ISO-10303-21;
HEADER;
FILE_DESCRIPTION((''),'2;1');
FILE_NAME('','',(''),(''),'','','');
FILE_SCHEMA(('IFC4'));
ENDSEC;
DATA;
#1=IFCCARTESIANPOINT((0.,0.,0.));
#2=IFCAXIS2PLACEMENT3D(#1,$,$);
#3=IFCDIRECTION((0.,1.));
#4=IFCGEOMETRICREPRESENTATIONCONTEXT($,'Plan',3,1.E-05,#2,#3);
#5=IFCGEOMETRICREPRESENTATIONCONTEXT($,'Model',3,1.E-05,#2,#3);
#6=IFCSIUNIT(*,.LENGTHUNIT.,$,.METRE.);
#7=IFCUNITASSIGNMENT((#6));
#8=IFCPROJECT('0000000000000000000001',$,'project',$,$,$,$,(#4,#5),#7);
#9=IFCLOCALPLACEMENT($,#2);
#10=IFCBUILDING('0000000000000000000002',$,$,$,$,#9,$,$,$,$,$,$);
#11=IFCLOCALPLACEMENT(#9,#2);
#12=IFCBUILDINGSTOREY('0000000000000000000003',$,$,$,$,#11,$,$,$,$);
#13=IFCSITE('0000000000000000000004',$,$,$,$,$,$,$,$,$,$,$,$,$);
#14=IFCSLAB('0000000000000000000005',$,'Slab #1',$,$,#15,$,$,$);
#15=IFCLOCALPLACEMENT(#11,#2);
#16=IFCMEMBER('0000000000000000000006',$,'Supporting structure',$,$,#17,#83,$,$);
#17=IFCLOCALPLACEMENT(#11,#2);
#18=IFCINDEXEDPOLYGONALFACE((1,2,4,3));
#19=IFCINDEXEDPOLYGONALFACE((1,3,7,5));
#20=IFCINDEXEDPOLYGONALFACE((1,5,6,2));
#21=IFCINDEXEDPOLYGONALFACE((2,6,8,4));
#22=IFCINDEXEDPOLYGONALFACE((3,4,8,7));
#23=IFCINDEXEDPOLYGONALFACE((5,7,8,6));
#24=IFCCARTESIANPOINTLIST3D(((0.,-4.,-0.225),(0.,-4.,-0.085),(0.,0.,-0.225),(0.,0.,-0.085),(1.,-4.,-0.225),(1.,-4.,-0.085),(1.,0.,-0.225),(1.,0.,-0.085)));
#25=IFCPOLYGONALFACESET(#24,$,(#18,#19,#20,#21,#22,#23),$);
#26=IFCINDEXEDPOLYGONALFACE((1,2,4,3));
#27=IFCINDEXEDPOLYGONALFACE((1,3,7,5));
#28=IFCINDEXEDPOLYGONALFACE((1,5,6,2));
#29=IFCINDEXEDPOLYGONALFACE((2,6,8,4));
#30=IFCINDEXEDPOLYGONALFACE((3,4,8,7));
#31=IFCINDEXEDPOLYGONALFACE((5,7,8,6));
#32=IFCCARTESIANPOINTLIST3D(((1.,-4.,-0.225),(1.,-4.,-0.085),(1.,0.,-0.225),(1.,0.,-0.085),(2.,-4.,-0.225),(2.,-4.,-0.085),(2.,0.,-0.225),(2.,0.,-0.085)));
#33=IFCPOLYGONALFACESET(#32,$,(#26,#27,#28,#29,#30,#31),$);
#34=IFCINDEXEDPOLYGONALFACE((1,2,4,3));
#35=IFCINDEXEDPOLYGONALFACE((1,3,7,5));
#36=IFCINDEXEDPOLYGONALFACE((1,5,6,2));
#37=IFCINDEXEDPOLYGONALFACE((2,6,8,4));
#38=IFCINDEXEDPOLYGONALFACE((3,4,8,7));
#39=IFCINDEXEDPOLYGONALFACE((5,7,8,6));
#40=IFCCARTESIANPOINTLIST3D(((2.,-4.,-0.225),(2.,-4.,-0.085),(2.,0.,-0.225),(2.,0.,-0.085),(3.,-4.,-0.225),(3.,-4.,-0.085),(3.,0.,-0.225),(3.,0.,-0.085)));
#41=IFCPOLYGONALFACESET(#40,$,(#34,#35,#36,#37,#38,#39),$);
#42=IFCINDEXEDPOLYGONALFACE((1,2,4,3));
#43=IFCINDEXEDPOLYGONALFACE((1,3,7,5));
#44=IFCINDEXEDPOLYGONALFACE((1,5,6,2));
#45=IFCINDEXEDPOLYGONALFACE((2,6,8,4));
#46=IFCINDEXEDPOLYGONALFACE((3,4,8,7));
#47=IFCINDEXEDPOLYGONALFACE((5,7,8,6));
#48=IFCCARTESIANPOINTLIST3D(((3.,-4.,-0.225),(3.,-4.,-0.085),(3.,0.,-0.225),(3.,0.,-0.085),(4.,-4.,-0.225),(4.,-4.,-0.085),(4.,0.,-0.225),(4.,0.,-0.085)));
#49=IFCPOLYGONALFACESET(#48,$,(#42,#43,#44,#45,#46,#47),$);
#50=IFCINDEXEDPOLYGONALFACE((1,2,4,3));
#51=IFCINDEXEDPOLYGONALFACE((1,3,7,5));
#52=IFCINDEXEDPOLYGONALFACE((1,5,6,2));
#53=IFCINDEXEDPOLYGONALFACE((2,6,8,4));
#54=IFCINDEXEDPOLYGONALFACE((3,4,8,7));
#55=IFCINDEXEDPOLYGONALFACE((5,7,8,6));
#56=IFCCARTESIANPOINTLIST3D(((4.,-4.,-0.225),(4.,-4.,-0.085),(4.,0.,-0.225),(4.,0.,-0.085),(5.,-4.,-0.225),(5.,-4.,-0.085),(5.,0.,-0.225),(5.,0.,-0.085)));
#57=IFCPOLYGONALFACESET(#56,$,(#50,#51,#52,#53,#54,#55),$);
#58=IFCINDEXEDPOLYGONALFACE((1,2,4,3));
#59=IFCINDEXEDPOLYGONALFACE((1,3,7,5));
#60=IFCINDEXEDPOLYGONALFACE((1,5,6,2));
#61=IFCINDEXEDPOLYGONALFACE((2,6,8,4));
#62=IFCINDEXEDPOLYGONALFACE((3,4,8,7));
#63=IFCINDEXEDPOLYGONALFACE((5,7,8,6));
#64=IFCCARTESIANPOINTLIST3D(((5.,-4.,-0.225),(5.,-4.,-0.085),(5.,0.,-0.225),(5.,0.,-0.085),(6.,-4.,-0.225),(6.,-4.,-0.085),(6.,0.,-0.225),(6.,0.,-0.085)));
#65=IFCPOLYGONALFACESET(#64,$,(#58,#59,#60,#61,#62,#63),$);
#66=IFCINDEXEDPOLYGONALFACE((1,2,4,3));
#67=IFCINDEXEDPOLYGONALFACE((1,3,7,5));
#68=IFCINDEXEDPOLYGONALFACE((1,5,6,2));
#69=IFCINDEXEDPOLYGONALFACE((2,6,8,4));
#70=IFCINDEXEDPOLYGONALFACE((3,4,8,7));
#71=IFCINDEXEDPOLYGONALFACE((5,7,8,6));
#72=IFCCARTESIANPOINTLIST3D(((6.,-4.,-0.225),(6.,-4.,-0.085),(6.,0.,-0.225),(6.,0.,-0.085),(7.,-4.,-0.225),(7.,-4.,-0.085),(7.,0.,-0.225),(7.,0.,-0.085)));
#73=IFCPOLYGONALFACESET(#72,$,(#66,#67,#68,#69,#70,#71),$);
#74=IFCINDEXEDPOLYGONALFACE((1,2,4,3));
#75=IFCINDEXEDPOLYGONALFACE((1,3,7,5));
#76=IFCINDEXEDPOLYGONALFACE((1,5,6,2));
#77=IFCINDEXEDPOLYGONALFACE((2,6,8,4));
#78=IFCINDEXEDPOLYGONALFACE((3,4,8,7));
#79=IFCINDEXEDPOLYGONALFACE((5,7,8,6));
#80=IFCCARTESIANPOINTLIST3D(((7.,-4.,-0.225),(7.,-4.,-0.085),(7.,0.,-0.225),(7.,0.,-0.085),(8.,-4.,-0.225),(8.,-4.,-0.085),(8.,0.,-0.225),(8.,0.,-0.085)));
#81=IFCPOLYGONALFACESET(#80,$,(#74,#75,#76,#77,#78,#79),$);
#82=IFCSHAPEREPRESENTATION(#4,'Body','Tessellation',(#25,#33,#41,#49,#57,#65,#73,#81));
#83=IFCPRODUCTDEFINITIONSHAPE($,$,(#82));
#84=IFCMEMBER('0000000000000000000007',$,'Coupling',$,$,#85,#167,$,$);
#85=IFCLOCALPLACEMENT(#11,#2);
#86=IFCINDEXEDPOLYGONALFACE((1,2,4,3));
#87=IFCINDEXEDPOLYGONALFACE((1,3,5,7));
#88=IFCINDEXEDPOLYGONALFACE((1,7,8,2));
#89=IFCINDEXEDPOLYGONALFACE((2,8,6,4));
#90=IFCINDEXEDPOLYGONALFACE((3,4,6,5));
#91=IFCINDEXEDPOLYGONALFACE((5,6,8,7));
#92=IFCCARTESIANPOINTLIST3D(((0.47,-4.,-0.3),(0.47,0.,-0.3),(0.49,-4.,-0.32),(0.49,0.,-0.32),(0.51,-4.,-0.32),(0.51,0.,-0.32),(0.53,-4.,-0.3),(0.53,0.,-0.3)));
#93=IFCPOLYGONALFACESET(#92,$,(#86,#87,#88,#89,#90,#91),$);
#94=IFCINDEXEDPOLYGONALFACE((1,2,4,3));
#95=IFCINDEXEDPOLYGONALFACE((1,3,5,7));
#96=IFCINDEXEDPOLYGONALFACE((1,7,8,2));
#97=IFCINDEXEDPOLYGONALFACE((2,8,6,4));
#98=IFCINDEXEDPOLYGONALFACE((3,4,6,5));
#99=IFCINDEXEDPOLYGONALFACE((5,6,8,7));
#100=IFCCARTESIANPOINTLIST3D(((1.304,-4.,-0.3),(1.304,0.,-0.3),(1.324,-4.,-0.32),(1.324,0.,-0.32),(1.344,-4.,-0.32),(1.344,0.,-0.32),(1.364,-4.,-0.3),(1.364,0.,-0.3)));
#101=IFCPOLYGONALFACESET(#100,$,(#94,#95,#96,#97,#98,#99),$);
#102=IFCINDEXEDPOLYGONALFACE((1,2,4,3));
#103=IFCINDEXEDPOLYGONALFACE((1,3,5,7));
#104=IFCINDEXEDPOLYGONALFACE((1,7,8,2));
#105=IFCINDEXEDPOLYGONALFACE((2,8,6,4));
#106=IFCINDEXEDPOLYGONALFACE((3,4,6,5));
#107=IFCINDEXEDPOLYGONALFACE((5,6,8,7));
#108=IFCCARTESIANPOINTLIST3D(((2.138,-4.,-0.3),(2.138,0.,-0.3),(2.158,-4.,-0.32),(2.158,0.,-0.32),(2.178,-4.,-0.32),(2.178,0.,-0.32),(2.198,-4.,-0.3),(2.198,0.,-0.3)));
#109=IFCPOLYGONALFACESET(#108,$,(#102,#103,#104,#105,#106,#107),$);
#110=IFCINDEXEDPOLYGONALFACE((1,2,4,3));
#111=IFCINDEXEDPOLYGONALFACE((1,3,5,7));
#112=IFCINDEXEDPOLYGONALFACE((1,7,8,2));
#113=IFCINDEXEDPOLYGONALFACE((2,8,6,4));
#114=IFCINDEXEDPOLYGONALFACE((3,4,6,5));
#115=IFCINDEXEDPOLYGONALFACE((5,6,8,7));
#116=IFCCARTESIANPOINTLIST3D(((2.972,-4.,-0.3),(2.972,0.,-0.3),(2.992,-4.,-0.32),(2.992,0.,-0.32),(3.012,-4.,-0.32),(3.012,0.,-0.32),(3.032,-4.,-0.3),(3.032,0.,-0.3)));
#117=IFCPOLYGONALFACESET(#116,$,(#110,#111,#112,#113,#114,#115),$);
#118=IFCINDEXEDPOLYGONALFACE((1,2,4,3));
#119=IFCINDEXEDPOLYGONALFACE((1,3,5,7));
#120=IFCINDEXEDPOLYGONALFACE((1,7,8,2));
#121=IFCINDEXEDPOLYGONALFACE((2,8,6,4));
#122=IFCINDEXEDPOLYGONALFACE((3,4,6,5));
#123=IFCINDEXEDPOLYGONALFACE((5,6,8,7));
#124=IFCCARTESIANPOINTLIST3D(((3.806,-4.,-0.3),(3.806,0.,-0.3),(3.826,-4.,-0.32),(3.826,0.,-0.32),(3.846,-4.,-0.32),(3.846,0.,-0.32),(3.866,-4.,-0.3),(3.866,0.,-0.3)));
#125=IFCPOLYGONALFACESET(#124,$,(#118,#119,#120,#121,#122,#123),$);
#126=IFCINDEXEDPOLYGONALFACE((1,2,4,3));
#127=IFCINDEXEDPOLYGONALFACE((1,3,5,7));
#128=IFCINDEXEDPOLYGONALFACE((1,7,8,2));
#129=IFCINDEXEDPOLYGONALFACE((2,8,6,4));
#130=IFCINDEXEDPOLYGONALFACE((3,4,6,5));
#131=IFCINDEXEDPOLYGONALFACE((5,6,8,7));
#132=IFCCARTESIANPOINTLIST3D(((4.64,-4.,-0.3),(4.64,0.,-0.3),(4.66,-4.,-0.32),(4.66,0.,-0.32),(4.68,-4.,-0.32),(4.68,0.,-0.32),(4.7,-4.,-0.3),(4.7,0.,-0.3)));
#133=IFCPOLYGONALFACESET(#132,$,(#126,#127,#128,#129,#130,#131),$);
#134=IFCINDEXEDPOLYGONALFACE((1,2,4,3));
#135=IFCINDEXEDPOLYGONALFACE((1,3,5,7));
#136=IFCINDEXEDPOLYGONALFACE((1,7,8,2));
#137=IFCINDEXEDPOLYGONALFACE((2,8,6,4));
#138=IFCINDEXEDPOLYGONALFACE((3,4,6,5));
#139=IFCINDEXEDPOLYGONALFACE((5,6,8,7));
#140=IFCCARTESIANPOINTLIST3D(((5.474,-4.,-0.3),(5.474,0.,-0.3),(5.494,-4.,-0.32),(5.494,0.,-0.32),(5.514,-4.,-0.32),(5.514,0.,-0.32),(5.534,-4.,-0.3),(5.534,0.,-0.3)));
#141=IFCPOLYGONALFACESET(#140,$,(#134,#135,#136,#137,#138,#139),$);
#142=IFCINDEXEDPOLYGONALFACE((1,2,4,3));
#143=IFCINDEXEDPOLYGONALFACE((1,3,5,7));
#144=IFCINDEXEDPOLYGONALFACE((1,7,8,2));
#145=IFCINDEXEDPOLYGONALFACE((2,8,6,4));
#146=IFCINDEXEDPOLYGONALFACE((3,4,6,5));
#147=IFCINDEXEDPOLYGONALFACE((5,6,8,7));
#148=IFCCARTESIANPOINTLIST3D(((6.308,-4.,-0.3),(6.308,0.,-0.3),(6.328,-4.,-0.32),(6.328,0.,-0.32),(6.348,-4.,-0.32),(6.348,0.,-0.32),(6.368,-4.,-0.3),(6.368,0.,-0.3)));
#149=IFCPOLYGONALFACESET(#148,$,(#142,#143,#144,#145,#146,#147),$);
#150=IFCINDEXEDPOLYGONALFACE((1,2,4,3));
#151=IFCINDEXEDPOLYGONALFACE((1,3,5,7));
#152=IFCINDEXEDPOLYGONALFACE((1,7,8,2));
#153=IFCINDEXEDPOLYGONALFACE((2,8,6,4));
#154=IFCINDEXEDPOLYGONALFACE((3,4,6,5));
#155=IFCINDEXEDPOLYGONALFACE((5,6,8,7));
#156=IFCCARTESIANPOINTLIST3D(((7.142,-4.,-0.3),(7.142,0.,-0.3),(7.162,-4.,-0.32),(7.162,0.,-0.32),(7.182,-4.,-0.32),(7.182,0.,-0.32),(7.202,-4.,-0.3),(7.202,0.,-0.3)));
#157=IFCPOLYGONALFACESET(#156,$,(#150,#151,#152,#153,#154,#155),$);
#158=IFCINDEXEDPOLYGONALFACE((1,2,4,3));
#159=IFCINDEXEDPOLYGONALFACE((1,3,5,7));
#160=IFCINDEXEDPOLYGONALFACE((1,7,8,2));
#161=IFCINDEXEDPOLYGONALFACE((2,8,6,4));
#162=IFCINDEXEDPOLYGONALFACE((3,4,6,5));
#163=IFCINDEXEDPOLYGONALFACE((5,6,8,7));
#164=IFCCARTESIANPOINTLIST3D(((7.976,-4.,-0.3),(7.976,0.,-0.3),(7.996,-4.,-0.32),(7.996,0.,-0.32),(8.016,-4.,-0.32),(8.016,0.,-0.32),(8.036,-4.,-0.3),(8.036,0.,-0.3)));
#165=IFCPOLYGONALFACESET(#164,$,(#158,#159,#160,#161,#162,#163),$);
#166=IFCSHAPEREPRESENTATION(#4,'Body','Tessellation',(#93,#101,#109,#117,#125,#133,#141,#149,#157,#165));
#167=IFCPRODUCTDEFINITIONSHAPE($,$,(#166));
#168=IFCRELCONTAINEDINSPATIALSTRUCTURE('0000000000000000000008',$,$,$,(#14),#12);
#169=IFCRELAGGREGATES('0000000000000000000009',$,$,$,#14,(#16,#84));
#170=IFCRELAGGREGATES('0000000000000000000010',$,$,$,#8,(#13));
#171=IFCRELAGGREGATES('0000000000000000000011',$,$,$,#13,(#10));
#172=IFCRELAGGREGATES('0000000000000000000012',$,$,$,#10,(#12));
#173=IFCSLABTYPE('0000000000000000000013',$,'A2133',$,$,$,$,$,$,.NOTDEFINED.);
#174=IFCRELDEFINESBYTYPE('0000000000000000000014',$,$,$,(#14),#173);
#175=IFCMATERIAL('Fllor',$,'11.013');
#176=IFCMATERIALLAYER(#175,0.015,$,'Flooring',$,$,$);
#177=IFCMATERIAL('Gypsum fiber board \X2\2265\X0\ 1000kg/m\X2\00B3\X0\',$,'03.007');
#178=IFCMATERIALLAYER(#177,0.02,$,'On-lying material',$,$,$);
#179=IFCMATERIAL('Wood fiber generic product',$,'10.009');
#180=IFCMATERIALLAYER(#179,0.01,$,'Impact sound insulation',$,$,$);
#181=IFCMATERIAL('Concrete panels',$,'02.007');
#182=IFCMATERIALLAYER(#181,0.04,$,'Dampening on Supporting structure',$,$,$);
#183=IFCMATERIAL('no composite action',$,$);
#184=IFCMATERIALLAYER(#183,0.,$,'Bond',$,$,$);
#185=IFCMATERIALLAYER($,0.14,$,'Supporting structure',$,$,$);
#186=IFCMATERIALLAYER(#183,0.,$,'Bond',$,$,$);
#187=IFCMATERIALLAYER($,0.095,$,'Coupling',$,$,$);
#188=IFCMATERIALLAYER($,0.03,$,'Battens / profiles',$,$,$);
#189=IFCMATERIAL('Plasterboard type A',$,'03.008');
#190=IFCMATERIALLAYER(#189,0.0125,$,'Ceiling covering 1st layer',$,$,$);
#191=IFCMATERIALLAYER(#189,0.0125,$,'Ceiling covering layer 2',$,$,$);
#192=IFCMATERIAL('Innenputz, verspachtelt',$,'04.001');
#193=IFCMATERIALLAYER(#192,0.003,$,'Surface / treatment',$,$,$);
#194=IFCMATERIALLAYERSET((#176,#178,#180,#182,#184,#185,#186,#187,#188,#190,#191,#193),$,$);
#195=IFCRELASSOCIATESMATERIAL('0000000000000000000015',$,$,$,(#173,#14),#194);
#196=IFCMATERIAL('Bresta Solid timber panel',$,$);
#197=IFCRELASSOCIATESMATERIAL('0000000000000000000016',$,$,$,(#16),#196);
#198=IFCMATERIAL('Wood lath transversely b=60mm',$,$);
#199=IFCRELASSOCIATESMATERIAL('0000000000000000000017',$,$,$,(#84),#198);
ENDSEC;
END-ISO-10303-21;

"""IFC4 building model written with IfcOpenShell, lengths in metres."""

from ifc_helpers import new_model, si_unit, direction, frame, frame_2d, origin, place, context, project, spatial, polyline, rectangle, outline, extrude, material, layer, layer_set, type_object, element, aggregate, save


model = new_model("IFC4")

# Units and contexts
plan_context = context("Plan", 3, precision=1e-05, world=origin(), true_north=direction((0.0, 1.0)))
model_context = context("Model", 3, precision=1e-05, world=origin(), true_north=direction((0.0, 1.0)))
ifc_project = project(units=[si_unit("LENGTHUNIT", "METRE")], contexts=[plan_context, model_context])

# Site, building, storey
site = spatial("IfcSite", under=ifc_project)
building_placement = place(None, origin())
building = spatial("IfcBuilding", under=site, at=building_placement)
storey_placement = place(building_placement, origin())
storey = spatial("IfcBuildingStorey", under=building, at=storey_placement)

# Slab, members
ifc_material_1 = material(Name="Fllor", Category="11.013")
ifc_layer_1 = layer(ifc_material_1, 0.015, Name="Flooring")
ifc_material_2 = material(Name="Gypsum fiber board ≥ 1000kg/m³", Category="03.007")
ifc_layer_2 = layer(ifc_material_2, 0.02, Name="On-lying material")
ifc_material_3 = material(Name="Wood fiber generic product", Category="10.009")
ifc_layer_3 = layer(ifc_material_3, 0.01, Name="Impact sound insulation")
ifc_material_4 = material(Name="Concrete panels", Category="02.007")
ifc_layer_4 = layer(ifc_material_4, 0.04, Name="Dampening on Supporting structure")
ifc_material_5 = material(Name="no composite action")
ifc_layer_5 = layer(ifc_material_5, 0.0, Name="Bond")
ifc_layer_6 = layer(None, 0.14, Name="Supporting structure")
ifc_layer_7 = layer(ifc_material_5, 0.0, Name="Bond")
ifc_layer_8 = layer(None, 0.095, Name="Coupling")
ifc_layer_9 = layer(None, 0.03, Name="Battens / profiles")
ifc_material_6 = material(Name="Plasterboard type A", Category="03.008")
ifc_layer_10 = layer(ifc_material_6, 0.0125, Name="Ceiling covering 1st layer")
ifc_layer_11 = layer(ifc_material_6, 0.0125, Name="Ceiling covering layer 2")
ifc_material_7 = material(Name="Innenputz, verspachtelt", Category="04.001")
ifc_layer_12 = layer(ifc_material_7, 0.003, Name="Surface / treatment")
ifc_layer_set = layer_set([ifc_layer_1, ifc_layer_2, ifc_layer_3, ifc_layer_4, ifc_layer_5, ifc_layer_6, ifc_layer_7, ifc_layer_8, ifc_layer_9, ifc_layer_10, ifc_layer_11, ifc_layer_12])
slab_type = type_object("IfcSlabType", Name="A2133", PredefinedType="NOTDEFINED", material=ifc_layer_set)
slab_placement = place(None, frame((0.0, 0.0, 0.0), z_axis=(0.0, 0.0, -1.0), x_axis=(1.0, 0.0, 0.0)))
slab = element("IfcSlab", 1, at=slab_placement, inside=storey, type_object=slab_type, material=ifc_layer_set, Name="Slab #1")
ifc_material_8 = material(Name="Bresta Solid timber panel")
member_1_placement = place(slab_placement, origin())
member_1 = element("IfcMember", 2, at=member_1_placement, material=ifc_material_8, Name="Supporting structure", context=plan_context, shape_type="SweptSolid", body=[
    extrude(rectangle(XDim=1.0, YDim=0.14, at=frame_2d((0.5, 0.07), x_axis=(1.0, 0.0))), frame((0.0, 4.0, 0.085), z_axis=(0.0, -1.0, 0.0), x_axis=(1.0, 0.0, 0.0)), (0.0, 0.0, 1.0), 4.0),
    extrude(rectangle(XDim=1.0, YDim=0.14, at=frame_2d((0.5, 0.07), x_axis=(1.0, 0.0))), frame((1.0, 4.0, 0.085), z_axis=(0.0, -1.0, 0.0), x_axis=(1.0, 0.0, 0.0)), (0.0, 0.0, 1.0), 4.0),
    extrude(rectangle(XDim=1.0, YDim=0.14, at=frame_2d((0.5, 0.07), x_axis=(1.0, 0.0))), frame((2.0, 4.0, 0.085), z_axis=(0.0, -1.0, 0.0), x_axis=(1.0, 0.0, 0.0)), (0.0, 0.0, 1.0), 4.0),
    extrude(rectangle(XDim=1.0, YDim=0.14, at=frame_2d((0.5, 0.07), x_axis=(1.0, 0.0))), frame((3.0, 4.0, 0.085), z_axis=(0.0, -1.0, 0.0), x_axis=(1.0, 0.0, 0.0)), (0.0, 0.0, 1.0), 4.0),
    extrude(rectangle(XDim=1.0, YDim=0.14, at=frame_2d((0.5, 0.07), x_axis=(1.0, 0.0))), frame((4.0, 4.0, 0.085), z_axis=(0.0, -1.0, 0.0), x_axis=(1.0, 0.0, 0.0)), (0.0, 0.0, 1.0), 4.0),
    extrude(rectangle(XDim=1.0, YDim=0.14, at=frame_2d((0.5, 0.07), x_axis=(1.0, 0.0))), frame((5.0, 4.0, 0.085), z_axis=(0.0, -1.0, 0.0), x_axis=(1.0, 0.0, 0.0)), (0.0, 0.0, 1.0), 4.0),
    extrude(rectangle(XDim=1.0, YDim=0.14, at=frame_2d((0.5, 0.07), x_axis=(1.0, 0.0))), frame((6.0, 4.0, 0.085), z_axis=(0.0, -1.0, 0.0), x_axis=(1.0, 0.0, 0.0)), (0.0, 0.0, 1.0), 4.0),
    extrude(rectangle(XDim=1.0, YDim=0.14, at=frame_2d((0.5, 0.07), x_axis=(1.0, 0.0))), frame((7.0, 4.0, 0.085), z_axis=(0.0, -1.0, 0.0), x_axis=(1.0, 0.0, 0.0)), (0.0, 0.0, 1.0), 4.0),
])
ifc_material_9 = material(Name="Wood lath transversely b=60mm")
member_2_placement = place(slab_placement, origin())
member_2 = element("IfcMember", 3, at=member_2_placement, material=ifc_material_9, Name="Coupling", context=plan_context, shape_type="SweptSolid", body=[
    extrude(outline(polyline([(0.0, 0.0), (0.06, 0.0), (0.04, 0.02), (0.02, 0.02), (0.0, 0.0)])), frame((0.47, 4.0, 0.3), z_axis=(0.0, -1.0, 0.0), x_axis=(1.0, 0.0, 0.0)), (0.0, 0.0, 1.0), 4.0),
    extrude(outline(polyline([(0.0, 0.0), (0.06, 0.0), (0.04, 0.02), (0.02, 0.02), (0.0, 0.0)])), frame((1.304, 4.0, 0.3), z_axis=(0.0, -1.0, 0.0), x_axis=(1.0, 0.0, 0.0)), (0.0, 0.0, 1.0), 4.0),
    extrude(outline(polyline([(0.0, 0.0), (0.06, 0.0), (0.04, 0.02), (0.02, 0.02), (0.0, 0.0)])), frame((2.138, 4.0, 0.3), z_axis=(0.0, -1.0, 0.0), x_axis=(1.0, 0.0, 0.0)), (0.0, 0.0, 1.0), 4.0),
    extrude(outline(polyline([(0.0, 0.0), (0.06, 0.0), (0.04, 0.02), (0.02, 0.02), (0.0, 0.0)])), frame((2.972, 4.0, 0.3), z_axis=(0.0, -1.0, 0.0), x_axis=(1.0, 0.0, 0.0)), (0.0, 0.0, 1.0), 4.0),
    extrude(outline(polyline([(0.0, 0.0), (0.06, 0.0), (0.04, 0.02), (0.02, 0.02), (0.0, 0.0)])), frame((3.806, 4.0, 0.3), z_axis=(0.0, -1.0, 0.0), x_axis=(1.0, 0.0, 0.0)), (0.0, 0.0, 1.0), 4.0),
    extrude(outline(polyline([(0.0, 0.0), (0.06, 0.0), (0.04, 0.02), (0.02, 0.02), (0.0, 0.0)])), frame((4.64, 4.0, 0.3), z_axis=(0.0, -1.0, 0.0), x_axis=(1.0, 0.0, 0.0)), (0.0, 0.0, 1.0), 4.0),
    extrude(outline(polyline([(0.0, 0.0), (0.06, 0.0), (0.04, 0.02), (0.02, 0.02), (0.0, 0.0)])), frame((5.474, 4.0, 0.3), z_axis=(0.0, -1.0, 0.0), x_axis=(1.0, 0.0, 0.0)), (0.0, 0.0, 1.0), 4.0),
    extrude(outline(polyline([(0.0, 0.0), (0.06, 0.0), (0.04, 0.02), (0.02, 0.02), (0.0, 0.0)])), frame((6.308, 4.0, 0.3), z_axis=(0.0, -1.0, 0.0), x_axis=(1.0, 0.0, 0.0)), (0.0, 0.0, 1.0), 4.0),
    extrude(outline(polyline([(0.0, 0.0), (0.06, 0.0), (0.04, 0.02), (0.02, 0.02), (0.0, 0.0)])), frame((7.142, 4.0, 0.3), z_axis=(0.0, -1.0, 0.0), x_axis=(1.0, 0.0, 0.0)), (0.0, 0.0, 1.0), 4.0),
    extrude(outline(polyline([(0.0, 0.0), (0.06, 0.0), (0.04, 0.02), (0.02, 0.02), (0.0, 0.0)])), frame((7.976, 4.0, 0.3), z_axis=(0.0, -1.0, 0.0), x_axis=(1.0, 0.0, 0.0)), (0.0, 0.0, 1.0), 4.0),
])
aggregate(slab, [member_1, member_2])

save(model, "model.ifc")
